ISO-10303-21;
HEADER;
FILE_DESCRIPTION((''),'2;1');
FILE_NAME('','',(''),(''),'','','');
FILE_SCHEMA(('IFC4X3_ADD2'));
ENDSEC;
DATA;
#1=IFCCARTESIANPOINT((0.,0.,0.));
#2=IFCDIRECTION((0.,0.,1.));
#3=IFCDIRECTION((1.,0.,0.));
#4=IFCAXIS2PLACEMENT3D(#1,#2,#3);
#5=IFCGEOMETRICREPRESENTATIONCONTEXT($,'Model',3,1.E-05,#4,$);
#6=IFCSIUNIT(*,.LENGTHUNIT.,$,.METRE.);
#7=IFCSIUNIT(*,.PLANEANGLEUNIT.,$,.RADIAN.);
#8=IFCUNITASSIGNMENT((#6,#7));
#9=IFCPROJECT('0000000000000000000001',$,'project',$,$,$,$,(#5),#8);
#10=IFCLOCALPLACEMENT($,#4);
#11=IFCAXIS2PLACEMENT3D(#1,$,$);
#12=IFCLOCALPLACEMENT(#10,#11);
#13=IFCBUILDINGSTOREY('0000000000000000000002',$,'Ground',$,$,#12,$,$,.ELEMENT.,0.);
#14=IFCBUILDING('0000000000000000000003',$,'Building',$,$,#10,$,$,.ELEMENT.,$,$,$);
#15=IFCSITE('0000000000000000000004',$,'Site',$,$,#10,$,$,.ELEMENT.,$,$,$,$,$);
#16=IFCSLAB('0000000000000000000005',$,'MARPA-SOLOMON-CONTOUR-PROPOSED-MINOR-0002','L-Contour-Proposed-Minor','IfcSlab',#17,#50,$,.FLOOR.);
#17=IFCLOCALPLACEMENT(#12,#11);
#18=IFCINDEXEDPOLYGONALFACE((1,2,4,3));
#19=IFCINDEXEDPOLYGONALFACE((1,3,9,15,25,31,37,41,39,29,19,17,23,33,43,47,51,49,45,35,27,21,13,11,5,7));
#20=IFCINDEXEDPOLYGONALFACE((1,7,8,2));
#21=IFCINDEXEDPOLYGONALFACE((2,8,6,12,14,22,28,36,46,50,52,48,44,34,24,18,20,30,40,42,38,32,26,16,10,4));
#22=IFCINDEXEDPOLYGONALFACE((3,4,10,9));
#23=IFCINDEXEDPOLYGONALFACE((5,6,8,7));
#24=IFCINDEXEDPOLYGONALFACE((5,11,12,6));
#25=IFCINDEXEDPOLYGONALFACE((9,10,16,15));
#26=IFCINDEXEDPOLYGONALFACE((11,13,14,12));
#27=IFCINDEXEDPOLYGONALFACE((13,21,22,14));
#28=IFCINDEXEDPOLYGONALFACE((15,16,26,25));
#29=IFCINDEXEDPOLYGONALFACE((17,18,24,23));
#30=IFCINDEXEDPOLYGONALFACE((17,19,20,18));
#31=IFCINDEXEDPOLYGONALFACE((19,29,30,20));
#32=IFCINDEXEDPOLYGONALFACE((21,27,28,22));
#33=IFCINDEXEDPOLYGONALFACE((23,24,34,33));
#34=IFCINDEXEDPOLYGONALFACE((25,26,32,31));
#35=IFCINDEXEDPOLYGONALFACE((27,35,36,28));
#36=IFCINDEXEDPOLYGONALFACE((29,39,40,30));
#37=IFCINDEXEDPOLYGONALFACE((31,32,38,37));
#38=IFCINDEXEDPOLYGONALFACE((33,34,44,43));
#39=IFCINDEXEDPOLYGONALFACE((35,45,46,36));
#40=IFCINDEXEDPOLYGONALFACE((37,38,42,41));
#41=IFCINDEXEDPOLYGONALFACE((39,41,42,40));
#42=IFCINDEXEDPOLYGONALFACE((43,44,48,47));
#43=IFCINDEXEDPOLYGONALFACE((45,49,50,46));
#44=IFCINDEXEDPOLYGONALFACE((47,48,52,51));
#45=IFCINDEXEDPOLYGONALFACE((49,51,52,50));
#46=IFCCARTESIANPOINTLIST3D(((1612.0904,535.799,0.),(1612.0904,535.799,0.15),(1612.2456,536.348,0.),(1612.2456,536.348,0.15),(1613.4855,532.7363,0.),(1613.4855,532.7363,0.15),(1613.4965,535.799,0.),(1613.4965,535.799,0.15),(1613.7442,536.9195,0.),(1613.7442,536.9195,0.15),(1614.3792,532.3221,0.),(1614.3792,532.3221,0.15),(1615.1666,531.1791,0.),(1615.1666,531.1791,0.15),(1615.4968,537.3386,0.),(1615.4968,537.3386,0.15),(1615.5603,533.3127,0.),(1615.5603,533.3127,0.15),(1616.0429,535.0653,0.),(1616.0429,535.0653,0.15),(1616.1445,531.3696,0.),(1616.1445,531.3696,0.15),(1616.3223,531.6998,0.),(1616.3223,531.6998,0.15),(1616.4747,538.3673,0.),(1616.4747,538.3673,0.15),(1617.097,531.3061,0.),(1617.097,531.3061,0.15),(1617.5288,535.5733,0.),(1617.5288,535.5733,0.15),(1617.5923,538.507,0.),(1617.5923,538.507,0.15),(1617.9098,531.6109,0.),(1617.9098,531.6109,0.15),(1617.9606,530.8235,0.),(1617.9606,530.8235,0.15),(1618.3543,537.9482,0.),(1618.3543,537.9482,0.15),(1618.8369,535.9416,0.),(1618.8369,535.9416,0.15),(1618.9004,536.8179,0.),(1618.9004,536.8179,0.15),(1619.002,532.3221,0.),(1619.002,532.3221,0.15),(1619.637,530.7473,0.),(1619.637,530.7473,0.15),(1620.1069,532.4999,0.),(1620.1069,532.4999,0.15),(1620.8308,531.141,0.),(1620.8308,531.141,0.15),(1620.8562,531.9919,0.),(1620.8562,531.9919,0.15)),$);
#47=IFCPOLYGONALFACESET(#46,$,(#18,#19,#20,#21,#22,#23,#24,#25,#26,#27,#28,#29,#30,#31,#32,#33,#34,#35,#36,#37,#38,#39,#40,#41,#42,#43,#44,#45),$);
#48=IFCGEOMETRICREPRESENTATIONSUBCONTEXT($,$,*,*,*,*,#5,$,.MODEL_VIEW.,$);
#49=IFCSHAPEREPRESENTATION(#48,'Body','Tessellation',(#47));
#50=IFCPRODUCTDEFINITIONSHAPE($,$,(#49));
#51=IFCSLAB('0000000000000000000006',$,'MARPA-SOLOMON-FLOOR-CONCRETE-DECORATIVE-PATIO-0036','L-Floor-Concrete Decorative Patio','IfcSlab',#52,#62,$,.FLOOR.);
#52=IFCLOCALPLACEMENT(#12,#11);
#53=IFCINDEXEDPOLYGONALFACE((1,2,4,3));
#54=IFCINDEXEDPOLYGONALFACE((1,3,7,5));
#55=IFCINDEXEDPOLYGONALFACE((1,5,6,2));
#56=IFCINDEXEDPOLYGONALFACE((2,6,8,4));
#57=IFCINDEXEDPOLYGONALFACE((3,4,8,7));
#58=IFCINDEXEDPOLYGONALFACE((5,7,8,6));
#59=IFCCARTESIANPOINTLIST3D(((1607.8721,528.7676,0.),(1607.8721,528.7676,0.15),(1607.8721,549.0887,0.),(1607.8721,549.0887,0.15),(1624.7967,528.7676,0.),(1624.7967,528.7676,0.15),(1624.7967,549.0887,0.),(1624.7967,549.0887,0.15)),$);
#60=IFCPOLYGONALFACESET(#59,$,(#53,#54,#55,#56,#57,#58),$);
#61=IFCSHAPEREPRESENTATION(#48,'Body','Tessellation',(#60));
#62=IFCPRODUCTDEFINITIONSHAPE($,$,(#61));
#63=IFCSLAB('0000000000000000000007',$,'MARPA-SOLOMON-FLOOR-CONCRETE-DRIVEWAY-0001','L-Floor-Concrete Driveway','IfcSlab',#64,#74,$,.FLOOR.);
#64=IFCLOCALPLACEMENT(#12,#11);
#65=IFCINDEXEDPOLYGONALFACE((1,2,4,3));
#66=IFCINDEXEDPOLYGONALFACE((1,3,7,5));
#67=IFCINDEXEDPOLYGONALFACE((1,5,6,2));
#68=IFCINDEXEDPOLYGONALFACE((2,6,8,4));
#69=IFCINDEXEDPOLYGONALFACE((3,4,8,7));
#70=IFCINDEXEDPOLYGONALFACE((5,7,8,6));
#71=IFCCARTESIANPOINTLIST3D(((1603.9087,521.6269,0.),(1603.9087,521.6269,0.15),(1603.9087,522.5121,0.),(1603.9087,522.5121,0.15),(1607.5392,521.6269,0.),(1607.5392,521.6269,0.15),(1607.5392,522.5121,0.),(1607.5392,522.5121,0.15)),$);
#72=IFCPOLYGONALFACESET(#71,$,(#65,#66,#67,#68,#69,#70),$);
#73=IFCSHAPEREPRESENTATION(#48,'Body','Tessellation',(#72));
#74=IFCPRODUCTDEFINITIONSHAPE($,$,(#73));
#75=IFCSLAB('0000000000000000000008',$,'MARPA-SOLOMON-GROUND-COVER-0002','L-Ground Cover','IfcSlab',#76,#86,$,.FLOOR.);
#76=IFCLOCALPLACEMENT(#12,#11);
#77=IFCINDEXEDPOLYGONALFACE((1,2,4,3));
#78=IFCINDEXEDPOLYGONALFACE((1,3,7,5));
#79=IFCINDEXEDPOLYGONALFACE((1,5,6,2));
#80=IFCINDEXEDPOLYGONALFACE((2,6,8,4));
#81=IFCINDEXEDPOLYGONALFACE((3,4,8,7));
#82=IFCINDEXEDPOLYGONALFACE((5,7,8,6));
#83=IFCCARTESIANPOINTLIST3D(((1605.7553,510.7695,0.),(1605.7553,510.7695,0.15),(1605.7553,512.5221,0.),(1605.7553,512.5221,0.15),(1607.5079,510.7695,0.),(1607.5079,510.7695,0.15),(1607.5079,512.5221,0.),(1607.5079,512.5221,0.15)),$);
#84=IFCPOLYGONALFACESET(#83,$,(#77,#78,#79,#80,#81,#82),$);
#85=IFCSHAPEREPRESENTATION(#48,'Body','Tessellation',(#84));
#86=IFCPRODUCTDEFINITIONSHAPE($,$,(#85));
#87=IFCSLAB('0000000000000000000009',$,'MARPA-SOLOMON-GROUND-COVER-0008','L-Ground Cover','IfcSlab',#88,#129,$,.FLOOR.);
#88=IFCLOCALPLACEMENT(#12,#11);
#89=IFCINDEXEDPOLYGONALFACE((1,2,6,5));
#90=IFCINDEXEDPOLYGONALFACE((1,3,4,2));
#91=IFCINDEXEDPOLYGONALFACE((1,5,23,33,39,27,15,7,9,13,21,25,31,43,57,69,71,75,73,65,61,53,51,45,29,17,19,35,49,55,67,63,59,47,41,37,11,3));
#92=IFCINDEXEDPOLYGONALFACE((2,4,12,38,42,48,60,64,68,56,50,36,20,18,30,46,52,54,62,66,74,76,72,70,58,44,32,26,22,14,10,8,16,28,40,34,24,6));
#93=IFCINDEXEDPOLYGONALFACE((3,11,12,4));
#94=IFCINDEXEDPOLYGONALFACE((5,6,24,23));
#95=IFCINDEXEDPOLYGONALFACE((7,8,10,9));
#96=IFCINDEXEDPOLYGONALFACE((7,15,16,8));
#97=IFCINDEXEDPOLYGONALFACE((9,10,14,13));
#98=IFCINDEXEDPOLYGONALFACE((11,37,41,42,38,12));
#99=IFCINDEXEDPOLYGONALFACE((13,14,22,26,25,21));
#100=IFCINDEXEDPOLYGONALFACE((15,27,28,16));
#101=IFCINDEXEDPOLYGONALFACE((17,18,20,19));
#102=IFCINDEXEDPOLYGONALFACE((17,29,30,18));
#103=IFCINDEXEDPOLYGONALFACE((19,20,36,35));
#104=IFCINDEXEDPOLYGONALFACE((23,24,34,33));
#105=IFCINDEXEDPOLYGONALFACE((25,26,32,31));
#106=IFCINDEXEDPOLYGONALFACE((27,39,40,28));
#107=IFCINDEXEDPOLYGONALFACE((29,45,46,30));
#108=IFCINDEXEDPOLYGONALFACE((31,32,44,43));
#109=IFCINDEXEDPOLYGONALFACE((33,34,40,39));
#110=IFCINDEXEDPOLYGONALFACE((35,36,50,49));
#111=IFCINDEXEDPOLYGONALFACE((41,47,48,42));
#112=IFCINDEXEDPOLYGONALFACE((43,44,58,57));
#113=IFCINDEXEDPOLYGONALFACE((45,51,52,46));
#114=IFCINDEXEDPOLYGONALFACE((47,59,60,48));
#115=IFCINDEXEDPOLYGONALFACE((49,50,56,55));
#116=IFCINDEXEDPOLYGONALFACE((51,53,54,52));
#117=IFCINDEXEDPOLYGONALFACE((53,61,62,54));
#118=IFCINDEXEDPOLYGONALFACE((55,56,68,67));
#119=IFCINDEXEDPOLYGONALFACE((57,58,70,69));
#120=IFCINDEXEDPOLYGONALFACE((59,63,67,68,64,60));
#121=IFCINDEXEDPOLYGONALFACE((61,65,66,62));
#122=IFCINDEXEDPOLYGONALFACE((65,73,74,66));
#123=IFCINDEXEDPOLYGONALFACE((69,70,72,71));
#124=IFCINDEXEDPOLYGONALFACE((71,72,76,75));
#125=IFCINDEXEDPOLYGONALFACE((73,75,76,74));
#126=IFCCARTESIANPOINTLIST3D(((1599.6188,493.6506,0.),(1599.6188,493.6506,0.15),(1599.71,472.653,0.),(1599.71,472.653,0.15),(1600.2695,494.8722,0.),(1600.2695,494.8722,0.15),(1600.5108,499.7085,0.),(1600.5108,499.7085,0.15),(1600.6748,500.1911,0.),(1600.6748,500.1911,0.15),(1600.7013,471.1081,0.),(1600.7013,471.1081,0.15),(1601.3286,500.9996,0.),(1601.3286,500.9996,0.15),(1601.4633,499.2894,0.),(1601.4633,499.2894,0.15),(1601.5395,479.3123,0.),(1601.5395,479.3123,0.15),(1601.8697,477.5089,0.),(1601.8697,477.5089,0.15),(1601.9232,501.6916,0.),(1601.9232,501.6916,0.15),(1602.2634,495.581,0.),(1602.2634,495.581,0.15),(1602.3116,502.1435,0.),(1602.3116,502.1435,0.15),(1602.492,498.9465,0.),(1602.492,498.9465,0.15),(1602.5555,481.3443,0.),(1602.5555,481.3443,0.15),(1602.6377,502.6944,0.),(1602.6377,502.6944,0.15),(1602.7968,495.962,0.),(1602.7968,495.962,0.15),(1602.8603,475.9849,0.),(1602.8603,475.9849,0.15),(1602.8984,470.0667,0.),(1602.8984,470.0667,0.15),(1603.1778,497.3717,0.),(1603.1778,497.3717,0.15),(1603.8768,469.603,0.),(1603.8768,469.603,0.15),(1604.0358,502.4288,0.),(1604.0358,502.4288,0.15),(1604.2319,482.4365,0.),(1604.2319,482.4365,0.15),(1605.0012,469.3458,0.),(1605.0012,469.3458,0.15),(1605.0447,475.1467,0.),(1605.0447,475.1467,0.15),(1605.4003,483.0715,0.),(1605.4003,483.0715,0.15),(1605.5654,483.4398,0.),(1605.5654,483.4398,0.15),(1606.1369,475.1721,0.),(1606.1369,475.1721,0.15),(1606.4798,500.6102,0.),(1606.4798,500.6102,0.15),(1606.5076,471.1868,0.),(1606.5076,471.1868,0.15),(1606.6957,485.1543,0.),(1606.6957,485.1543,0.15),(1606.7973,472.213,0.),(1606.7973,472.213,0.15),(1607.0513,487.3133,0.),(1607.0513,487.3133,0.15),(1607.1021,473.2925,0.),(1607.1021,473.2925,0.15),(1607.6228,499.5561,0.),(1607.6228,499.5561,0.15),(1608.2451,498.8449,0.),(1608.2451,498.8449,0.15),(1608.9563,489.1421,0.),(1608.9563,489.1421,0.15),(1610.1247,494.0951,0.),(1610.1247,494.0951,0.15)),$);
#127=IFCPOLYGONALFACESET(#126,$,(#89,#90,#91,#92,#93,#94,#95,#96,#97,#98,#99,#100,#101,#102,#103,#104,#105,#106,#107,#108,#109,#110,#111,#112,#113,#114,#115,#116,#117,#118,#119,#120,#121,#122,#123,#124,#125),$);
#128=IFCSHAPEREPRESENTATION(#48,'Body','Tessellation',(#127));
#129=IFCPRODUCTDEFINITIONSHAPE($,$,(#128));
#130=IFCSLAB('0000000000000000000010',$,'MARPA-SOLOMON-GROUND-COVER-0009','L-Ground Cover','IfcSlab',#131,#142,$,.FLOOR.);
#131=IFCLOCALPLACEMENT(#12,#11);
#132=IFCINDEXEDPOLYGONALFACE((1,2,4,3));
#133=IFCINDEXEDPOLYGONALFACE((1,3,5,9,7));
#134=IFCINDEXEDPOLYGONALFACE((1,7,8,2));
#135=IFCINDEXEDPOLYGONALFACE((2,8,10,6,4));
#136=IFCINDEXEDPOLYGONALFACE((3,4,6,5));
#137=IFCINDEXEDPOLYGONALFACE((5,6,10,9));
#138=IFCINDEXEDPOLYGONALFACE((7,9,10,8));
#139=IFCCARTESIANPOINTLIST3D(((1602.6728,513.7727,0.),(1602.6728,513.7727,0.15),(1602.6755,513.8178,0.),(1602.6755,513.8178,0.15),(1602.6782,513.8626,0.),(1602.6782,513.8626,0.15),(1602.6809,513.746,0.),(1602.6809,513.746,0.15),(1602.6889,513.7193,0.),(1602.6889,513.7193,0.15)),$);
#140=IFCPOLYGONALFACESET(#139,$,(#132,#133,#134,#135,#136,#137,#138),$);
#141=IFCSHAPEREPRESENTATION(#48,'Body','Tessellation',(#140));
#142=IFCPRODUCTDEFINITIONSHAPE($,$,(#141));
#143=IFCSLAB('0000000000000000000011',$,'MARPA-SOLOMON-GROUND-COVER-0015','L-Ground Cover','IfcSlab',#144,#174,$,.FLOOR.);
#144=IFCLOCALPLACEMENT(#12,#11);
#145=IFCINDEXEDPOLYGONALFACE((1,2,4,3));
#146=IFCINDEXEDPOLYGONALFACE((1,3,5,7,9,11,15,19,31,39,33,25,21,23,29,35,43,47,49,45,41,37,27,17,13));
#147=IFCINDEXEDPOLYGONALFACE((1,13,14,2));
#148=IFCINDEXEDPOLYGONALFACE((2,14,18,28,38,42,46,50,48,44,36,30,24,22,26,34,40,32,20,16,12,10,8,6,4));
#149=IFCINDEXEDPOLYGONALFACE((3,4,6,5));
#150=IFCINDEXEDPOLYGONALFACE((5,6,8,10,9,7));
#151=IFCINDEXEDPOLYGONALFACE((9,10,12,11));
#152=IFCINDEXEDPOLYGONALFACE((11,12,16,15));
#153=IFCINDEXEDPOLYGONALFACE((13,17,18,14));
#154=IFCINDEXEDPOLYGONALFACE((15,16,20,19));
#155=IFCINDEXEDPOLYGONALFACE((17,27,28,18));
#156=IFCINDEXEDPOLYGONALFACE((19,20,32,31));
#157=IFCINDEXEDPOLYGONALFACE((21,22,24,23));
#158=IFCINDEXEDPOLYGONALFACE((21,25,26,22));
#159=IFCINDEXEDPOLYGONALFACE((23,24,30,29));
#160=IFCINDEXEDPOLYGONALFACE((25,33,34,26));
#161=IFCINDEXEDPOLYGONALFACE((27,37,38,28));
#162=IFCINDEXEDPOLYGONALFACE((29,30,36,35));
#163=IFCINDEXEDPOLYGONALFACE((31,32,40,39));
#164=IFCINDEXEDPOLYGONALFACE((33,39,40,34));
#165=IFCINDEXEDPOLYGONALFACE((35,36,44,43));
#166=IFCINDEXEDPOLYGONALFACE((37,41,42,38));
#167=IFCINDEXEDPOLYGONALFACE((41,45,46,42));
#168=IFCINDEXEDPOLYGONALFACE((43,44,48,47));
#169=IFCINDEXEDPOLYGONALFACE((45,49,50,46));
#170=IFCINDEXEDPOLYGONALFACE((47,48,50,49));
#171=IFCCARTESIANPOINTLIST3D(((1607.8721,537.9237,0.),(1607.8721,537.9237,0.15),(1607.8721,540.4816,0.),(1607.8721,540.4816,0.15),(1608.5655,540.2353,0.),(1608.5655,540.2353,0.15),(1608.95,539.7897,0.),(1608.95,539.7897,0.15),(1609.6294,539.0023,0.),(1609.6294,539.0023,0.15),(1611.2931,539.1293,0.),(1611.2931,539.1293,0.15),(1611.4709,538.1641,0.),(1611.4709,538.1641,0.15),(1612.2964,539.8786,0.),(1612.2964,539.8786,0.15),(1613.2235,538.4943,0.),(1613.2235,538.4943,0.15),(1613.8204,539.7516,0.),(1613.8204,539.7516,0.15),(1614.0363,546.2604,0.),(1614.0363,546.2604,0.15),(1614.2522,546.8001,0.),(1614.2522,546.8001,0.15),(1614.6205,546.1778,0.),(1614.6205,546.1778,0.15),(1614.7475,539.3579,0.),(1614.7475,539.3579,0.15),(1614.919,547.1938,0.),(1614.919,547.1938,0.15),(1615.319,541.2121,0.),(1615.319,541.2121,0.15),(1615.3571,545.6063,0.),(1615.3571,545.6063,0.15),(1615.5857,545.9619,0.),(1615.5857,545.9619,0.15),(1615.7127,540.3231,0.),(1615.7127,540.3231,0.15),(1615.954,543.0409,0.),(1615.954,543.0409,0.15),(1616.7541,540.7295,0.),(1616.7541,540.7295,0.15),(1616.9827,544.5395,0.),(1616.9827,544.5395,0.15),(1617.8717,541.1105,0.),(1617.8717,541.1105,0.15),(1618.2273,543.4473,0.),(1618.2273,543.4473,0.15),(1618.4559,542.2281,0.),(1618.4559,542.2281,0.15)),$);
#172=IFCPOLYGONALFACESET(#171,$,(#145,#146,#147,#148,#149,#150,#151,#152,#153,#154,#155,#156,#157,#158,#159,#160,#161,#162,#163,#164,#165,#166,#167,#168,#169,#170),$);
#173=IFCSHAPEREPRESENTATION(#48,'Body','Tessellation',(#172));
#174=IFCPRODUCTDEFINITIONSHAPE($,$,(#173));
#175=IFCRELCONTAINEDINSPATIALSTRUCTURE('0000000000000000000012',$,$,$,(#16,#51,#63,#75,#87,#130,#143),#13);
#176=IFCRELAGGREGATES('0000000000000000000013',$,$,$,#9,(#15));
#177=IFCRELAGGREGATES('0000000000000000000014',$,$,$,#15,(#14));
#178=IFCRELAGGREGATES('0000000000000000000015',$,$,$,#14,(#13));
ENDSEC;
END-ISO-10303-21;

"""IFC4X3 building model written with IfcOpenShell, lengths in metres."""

from ifc_helpers import new_model, si_unit, frame, frame_2d, origin, origin_with_axes, place, context, subcontext, project, spatial, polyline, rectangle, outline, extrude, element, save


model = new_model("IFC4X3")

# Units and contexts
model_context = context("Model", 3, precision=1e-05, world=origin_with_axes())
sub_context = subcontext(model_context, None, None, "MODEL_VIEW")
ifc_project = project(units=[si_unit("LENGTHUNIT", "METRE"), si_unit("PLANEANGLEUNIT", "RADIAN")], contexts=[model_context])

# Site, building, storey
placement = place(None, origin_with_axes())
site = spatial("IfcSite", under=ifc_project, at=placement, Name="Site", CompositionType="ELEMENT")
building = spatial("IfcBuilding", under=site, at=placement, Name="Building", CompositionType="ELEMENT")
storey_placement = place(placement, origin())
storey = spatial("IfcBuildingStorey", under=building, at=storey_placement, Name="Ground", CompositionType="ELEMENT", Elevation=0.0)

# Slabs
slab_1_placement = place(storey_placement, frame((1612.0904, 530.7473, 0.0)))
element("IfcSlab", 1, at=slab_1_placement, inside=storey, Name="MARPA-SOLOMON-CONTOUR-PROPOSED-MINOR-0002", Description="L-Contour-Proposed-Minor", ObjectType="IfcSlab", PredefinedType="FLOOR", context=sub_context, shape_type="SweptSolid", body=[
    extrude(outline(polyline([(0.0, 5.0517), (0.1552, 5.6007), (1.6538, 6.1722), (3.4064, 6.5913), (4.3843, 7.62), (5.5019, 7.7597), (6.2639, 7.2009), (6.81, 6.0706), (6.7465, 5.1943), (5.4384, 4.826), (3.9525, 4.318), (3.4699, 2.5654), (4.2319, 0.9525), (5.8194, 0.8636), (6.9116, 1.5748), (8.0165, 1.7526), (8.7658, 1.2446), (8.7404, 0.3937), (7.5466, 0.0), (5.8702, 0.0762), (5.0066, 0.5588), (4.0541, 0.6223), (3.0762, 0.4318), (2.2888, 1.5748), (1.3951, 1.989), (1.4061, 5.0517), (0.0, 5.0517)])), origin(), (0.0, 0.0, 1.0), 0.15),
])
slab_2_placement = place(storey_placement, frame((1607.8721, 528.7676, 0.0)))
element("IfcSlab", 2, at=slab_2_placement, inside=storey, Name="MARPA-SOLOMON-FLOOR-CONCRETE-DECORATIVE-PATIO-0036", Description="L-Floor-Concrete Decorative Patio", ObjectType="IfcSlab", PredefinedType="FLOOR", context=sub_context, shape_type="SweptSolid", body=[
    extrude(rectangle(XDim=16.9247, YDim=20.3212, at=frame_2d((8.4623, 10.1606))), origin(), (0.0, 0.0, 1.0), 0.15),
])
slab_3_placement = place(storey_placement, frame((1603.9087, 521.6269, 0.0)))
element("IfcSlab", 3, at=slab_3_placement, inside=storey, Name="MARPA-SOLOMON-FLOOR-CONCRETE-DRIVEWAY-0001", Description="L-Floor-Concrete Driveway", ObjectType="IfcSlab", PredefinedType="FLOOR", context=sub_context, shape_type="SweptSolid", body=[
    extrude(outline(polyline([(0.0, 0.8852), (3.6306, 0.8852), (3.6306, 0.0), (0.0, 0.0), (0.0, 0.8852)])), origin(), (0.0, 0.0, 1.0), 0.15),
])
slab_4_placement = place(storey_placement, frame((1605.7553, 510.7695, 0.0)))
element("IfcSlab", 4, at=slab_4_placement, inside=storey, Name="MARPA-SOLOMON-GROUND-COVER-0002", Description="L-Ground Cover", ObjectType="IfcSlab", PredefinedType="FLOOR", context=sub_context, shape_type="SweptSolid", body=[
    extrude(outline(polyline([(0.0, 1.7526), (1.7526, 1.7526), (1.7526, 0.0), (0.0, 0.0), (0.0, 1.7526)])), origin(), (0.0, 0.0, 1.0), 0.15),
])
slab_5_placement = place(storey_placement, frame((1599.6188, 469.3458, 0.0)))
element("IfcSlab", 5, at=slab_5_placement, inside=storey, Name="MARPA-SOLOMON-GROUND-COVER-0008", Description="L-Ground Cover", ObjectType="IfcSlab", PredefinedType="FLOOR", context=sub_context, shape_type="SweptSolid", body=[
    extrude(outline(polyline([(0.6507, 25.5265), (0.0, 24.3049), (0.0912, 3.3073), (1.0825, 1.7624), (3.2796, 0.721), (4.258, 0.2572), (5.3824, 0.0), (6.8887, 1.8411), (7.1785, 2.8673), (7.4833, 3.9468), (6.5181, 5.8264), (5.4259, 5.801), (3.2415, 6.6392), (2.2509, 8.1632), (1.9207, 9.9666), (2.9367, 11.9986), (4.6131, 13.0908), (5.7815, 13.7258), (5.9466, 14.0941), (7.0769, 15.8086), (7.4325, 17.9676), (9.3375, 19.7964), (10.5059, 24.7494), (8.6263, 29.4992), (8.004, 30.2104), (6.861, 31.2645), (4.417, 33.083), (3.0189, 33.3486), (2.6928, 32.7978), (2.3044, 32.3458), (1.7098, 31.6539), (1.056, 30.8454), (0.892, 30.3628), (1.8445, 29.9437), (2.8732, 29.6008), (3.559, 28.026), (3.178, 26.6163), (2.6446, 26.2353), (0.6507, 25.5265)])), origin(), (0.0, 0.0, 1.0), 0.15),
])
slab_6_placement = place(storey_placement, frame((1602.6728, 513.7193, 0.0)))
element("IfcSlab", 6, at=slab_6_placement, inside=storey, Name="MARPA-SOLOMON-GROUND-COVER-0009", Description="L-Ground Cover", ObjectType="IfcSlab", PredefinedType="FLOOR", context=sub_context, shape_type="SweptSolid", body=[
    extrude(outline(polyline([(0.0054, 0.1433), (0.0027, 0.0985), (0.0, 0.0534), (0.0081, 0.0267), (0.0161, 0.0), (0.0054, 0.1433)])), origin(), (0.0, 0.0, 1.0), 0.15),
])
slab_7_placement = place(storey_placement, frame((1607.8721, 537.9237, 0.0)))
element("IfcSlab", 7, at=slab_7_placement, inside=storey, Name="MARPA-SOLOMON-GROUND-COVER-0015", Description="L-Ground Cover", ObjectType="IfcSlab", PredefinedType="FLOOR", context=sub_context, shape_type="SweptSolid", body=[
    extrude(outline(polyline([(0.0, 0.0), (3.5988, 0.2404), (5.3514, 0.5706), (6.8754, 1.4342), (7.8406, 2.3994), (8.882, 2.8058), (9.9996, 3.1868), (10.5838, 4.3044), (10.3552, 5.5236), (9.1106, 6.6158), (7.7136, 8.0382), (7.0469, 9.2701), (6.3801, 8.8764), (6.1642, 8.3367), (6.7484, 8.2541), (7.485, 7.6826), (8.0819, 5.1172), (7.4469, 3.2884), (5.9483, 1.8279), (4.4243, 1.9549), (3.421, 1.2056), (1.7573, 1.0786), (1.0779, 1.866), (0.6934, 2.3115), (0.0, 2.5578), (0.0, 0.0)])), origin(), (0.0, 0.0, 1.0), 0.15),
])

save(model, "model.ifc")
